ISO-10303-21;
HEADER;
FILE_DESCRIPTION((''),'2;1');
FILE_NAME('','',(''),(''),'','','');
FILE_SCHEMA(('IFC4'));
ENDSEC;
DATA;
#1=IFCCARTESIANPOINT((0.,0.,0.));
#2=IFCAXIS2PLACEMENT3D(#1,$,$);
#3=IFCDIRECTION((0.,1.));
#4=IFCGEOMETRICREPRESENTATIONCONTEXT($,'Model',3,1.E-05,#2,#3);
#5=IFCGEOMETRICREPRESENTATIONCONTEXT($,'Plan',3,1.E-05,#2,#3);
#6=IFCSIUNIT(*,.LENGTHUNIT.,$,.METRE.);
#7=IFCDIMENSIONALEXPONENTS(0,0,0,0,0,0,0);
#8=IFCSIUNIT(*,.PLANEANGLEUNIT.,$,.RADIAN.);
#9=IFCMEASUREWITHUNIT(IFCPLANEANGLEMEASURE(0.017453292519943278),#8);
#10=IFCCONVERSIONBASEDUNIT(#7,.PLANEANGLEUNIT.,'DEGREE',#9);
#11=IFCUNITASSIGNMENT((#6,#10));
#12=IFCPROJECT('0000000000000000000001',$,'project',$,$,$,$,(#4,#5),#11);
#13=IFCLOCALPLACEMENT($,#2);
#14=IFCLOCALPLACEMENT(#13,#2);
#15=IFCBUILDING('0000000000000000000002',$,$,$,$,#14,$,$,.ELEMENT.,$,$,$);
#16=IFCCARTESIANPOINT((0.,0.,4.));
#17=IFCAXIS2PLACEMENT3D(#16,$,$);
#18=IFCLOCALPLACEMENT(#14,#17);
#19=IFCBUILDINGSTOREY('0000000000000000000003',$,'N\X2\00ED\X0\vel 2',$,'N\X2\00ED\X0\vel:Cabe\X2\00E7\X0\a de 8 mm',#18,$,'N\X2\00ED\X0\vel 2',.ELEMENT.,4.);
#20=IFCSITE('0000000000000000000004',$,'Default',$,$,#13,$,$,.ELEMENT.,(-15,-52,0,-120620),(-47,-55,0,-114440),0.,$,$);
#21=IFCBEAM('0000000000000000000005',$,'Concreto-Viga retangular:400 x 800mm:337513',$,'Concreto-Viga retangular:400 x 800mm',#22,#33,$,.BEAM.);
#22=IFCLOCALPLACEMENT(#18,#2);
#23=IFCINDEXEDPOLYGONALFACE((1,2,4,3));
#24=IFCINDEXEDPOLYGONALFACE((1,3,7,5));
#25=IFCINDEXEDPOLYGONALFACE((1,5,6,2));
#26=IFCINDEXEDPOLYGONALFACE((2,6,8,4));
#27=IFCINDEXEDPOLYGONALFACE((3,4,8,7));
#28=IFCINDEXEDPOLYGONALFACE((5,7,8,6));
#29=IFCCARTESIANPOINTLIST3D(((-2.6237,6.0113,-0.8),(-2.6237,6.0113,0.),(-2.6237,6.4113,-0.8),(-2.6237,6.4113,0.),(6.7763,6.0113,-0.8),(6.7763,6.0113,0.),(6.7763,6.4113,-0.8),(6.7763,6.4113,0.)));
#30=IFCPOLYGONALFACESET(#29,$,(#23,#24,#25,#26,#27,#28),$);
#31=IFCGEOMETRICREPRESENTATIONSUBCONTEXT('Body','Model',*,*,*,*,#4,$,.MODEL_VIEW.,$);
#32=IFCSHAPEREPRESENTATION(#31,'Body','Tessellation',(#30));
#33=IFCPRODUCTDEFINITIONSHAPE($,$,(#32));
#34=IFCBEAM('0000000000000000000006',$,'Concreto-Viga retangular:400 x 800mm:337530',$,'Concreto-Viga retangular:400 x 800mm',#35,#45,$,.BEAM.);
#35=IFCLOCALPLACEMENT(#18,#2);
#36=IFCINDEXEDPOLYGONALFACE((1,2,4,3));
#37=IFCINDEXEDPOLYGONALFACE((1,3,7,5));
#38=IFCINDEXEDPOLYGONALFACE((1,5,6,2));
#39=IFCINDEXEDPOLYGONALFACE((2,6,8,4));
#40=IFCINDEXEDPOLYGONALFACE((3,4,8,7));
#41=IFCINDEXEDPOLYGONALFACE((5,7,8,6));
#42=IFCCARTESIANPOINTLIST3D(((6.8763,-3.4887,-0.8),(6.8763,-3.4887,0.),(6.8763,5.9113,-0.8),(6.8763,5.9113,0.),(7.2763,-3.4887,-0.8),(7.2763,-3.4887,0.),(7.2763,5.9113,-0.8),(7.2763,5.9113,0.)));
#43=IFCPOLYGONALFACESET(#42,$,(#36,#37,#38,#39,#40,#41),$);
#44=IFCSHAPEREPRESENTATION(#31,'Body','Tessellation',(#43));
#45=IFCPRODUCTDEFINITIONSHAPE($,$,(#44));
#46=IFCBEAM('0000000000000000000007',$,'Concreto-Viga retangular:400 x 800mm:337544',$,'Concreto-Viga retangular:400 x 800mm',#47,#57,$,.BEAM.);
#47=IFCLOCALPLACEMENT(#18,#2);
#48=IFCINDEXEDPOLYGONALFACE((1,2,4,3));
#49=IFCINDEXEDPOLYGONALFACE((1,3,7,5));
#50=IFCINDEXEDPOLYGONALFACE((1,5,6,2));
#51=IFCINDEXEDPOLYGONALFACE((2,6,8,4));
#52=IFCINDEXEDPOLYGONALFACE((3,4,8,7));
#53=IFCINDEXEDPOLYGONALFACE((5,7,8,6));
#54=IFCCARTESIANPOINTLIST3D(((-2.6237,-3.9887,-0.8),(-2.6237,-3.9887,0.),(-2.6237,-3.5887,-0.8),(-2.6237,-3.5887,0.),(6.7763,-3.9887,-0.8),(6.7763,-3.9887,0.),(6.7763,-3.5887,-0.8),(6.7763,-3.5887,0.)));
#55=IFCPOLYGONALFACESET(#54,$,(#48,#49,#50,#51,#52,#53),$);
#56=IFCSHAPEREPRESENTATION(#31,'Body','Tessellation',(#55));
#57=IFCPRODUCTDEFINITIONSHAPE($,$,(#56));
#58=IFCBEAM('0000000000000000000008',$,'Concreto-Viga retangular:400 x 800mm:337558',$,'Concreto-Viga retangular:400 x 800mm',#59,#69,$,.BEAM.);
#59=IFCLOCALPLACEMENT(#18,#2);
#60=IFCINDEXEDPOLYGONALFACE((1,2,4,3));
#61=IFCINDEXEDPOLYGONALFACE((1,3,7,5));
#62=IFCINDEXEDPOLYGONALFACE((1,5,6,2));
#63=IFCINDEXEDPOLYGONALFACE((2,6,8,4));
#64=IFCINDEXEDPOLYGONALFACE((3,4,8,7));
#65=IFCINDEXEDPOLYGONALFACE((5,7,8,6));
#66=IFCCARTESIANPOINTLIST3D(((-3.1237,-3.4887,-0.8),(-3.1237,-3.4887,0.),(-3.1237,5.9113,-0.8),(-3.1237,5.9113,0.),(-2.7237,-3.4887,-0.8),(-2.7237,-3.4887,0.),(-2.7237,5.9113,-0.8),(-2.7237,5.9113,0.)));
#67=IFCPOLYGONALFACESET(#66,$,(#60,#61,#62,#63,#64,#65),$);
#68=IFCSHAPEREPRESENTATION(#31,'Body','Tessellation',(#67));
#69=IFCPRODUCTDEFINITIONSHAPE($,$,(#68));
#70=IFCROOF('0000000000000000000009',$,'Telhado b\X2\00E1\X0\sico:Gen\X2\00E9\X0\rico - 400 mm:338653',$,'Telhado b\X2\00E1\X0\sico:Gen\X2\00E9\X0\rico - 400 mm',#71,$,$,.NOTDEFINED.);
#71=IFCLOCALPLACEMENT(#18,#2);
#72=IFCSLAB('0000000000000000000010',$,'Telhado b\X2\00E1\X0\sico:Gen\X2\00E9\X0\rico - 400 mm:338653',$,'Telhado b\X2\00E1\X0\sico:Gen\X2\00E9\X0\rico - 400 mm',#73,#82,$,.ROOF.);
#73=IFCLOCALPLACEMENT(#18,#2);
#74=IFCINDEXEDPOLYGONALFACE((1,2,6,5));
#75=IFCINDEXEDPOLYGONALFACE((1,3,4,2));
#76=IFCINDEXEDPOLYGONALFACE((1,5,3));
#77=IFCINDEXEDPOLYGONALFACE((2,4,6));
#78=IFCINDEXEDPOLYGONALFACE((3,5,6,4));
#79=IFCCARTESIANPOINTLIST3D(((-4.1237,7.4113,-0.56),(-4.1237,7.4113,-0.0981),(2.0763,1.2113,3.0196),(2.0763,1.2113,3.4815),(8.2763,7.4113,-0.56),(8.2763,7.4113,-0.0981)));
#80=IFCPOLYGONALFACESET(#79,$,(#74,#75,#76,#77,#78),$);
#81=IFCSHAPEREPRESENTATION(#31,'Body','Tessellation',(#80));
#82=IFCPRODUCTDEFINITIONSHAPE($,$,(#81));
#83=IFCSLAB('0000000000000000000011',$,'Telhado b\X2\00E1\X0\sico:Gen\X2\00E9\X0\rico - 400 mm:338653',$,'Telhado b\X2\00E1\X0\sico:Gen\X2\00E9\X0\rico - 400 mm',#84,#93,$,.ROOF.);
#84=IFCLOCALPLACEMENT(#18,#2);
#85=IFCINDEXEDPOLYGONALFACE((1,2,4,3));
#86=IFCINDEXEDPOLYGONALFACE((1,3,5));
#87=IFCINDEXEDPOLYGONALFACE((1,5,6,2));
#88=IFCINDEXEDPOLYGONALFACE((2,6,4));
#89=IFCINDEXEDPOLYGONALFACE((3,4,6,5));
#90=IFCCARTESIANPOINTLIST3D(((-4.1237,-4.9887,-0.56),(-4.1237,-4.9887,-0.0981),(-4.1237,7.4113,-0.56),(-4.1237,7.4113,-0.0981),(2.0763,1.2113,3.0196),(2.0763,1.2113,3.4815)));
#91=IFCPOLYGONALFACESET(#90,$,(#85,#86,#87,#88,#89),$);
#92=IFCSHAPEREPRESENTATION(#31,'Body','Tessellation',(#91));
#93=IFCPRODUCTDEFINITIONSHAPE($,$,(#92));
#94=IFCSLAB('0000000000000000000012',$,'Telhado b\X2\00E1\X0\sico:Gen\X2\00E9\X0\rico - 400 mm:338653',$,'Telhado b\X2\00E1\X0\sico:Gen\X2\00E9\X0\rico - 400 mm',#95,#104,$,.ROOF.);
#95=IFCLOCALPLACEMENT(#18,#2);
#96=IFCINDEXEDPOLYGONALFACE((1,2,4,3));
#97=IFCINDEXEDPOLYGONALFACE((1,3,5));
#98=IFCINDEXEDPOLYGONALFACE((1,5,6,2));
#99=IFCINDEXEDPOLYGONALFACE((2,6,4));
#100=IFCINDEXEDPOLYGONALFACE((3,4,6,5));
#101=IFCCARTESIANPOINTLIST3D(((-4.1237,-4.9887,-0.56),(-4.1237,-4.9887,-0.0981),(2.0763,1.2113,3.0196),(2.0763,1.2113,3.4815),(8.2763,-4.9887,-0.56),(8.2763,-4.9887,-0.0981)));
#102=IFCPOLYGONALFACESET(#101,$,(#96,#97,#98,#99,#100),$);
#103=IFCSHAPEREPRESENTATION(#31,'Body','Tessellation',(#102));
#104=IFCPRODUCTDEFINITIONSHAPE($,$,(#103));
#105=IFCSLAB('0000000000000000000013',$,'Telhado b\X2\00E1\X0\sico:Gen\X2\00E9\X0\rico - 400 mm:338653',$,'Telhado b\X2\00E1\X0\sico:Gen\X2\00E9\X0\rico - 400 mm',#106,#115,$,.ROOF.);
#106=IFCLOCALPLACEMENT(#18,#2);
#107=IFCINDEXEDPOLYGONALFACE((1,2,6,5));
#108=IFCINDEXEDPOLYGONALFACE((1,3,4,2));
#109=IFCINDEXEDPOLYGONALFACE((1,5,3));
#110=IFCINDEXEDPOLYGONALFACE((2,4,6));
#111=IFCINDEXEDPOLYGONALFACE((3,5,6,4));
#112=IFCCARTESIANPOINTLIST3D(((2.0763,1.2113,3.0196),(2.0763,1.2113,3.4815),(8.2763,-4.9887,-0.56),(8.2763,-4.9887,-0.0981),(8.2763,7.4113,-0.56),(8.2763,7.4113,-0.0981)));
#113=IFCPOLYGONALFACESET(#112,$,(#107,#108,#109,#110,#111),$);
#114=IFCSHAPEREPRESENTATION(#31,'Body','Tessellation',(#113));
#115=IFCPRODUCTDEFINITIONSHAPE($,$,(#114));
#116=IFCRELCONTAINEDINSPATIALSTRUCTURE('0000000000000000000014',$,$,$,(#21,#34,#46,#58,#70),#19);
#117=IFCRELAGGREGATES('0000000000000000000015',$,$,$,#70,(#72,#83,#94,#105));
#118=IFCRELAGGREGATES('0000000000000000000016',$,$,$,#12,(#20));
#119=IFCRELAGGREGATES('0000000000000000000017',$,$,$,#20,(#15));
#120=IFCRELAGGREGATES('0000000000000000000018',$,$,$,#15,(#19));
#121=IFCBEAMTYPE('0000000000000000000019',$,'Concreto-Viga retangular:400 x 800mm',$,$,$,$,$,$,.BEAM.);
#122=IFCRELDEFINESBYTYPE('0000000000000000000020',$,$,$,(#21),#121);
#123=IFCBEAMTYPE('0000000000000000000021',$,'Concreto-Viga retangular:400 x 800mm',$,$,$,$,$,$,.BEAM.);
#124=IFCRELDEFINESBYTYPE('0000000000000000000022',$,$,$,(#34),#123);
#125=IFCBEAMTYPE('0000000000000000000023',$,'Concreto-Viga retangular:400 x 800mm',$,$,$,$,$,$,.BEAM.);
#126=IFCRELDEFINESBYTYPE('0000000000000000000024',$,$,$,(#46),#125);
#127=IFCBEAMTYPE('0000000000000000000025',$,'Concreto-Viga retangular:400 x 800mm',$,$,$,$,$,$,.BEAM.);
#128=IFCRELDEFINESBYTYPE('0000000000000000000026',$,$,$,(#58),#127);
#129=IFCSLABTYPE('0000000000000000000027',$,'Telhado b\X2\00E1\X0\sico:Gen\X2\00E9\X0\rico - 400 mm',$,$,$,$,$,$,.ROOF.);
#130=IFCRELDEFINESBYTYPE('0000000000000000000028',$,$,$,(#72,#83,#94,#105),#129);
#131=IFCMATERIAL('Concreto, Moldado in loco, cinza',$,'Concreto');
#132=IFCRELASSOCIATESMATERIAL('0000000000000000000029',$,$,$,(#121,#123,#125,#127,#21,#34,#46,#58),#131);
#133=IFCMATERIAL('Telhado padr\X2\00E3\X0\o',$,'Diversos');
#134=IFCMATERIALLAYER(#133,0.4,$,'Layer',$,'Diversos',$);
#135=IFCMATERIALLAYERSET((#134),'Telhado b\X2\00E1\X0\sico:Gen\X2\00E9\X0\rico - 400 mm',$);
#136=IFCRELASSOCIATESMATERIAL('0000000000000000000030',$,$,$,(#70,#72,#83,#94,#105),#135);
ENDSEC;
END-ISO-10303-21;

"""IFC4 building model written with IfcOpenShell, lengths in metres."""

from ifc_helpers import new_model, entity, si_unit, converted_unit, direction, frame, frame_2d, origin, origin_2d_with_axis, place, context, subcontext, project, spatial, polyline, rectangle, outline, extrude, source, transform, mapped, material, layer, layer_set, material_profile, profile_set, profile_usage, type_object, type_shapes, element, aggregate, save


model = new_model("IFC4")

# Units and contexts
model_context = context("Model", 3, precision=1e-05, world=origin(), true_north=direction((0.0, 1.0)))
plan_context = context("Plan", 3, precision=1e-05, world=origin(), true_north=direction((0.0, 1.0)))
body_context = subcontext(model_context, "Body", "Model", "MODEL_VIEW")
ifc_project = project(units=[si_unit("LENGTHUNIT", "METRE"), converted_unit("PLANEANGLEUNIT", "DEGREE", entity("IfcPlaneAngleMeasure", 0.017453292519943278), si_unit("PLANEANGLEUNIT", "RADIAN"), dimensions=[0, 0, 0, 0, 0, 0, 0])], contexts=[model_context, plan_context])

# Site, building, storey
site_placement = place(None, origin())
site = spatial("IfcSite", under=ifc_project, at=site_placement, Name="Default", CompositionType="ELEMENT", RefLatitude=(-15, -52, 0, -120620), RefLongitude=(-47, -55, 0, -114440), RefElevation=0.0)
building_placement = place(site_placement, origin())
building = spatial("IfcBuilding", under=site, at=building_placement, CompositionType="ELEMENT")
storey_placement = place(building_placement, frame((0.0, 0.0, 4.0)))
storey = spatial("IfcBuildingStorey", under=building, at=storey_placement, Name="Nível 2", ObjectType="Nível:Cabeça de 8 mm", LongName="Nível 2", CompositionType="ELEMENT", Elevation=4.0)

# Beams
ifc_material_1 = material(Name="Concreto, Moldado in loco, cinza", Category="Concreto")
ifc_material_profile = material_profile(ifc_material_1, rectangle(XDim=0.8, YDim=0.4, at=frame_2d((0.0, 0.0), x_axis=(1.0, 0.0))), Name="400 x 800mm")
ifc_profile_set = profile_set([ifc_material_profile], Name="400 x 800mm")
ifc_profile_usage = profile_usage(ifc_profile_set, cardinal=8)
beam_type_1 = type_object("IfcBeamType", Name="Concreto-Viga retangular:400 x 800mm", PredefinedType="BEAM", material=ifc_profile_set)
shared_shape_1 = source(origin(), body_context, "Body", "SweptSolid", [
    extrude(rectangle(XDim=0.8, YDim=0.4, at=frame_2d((0.0, 0.0), x_axis=(1.0, 0.0))), frame((-2.6237, 6.2113, 3.6), z_axis=(1.0, 0.0, 0.0), x_axis=(0.0, 0.0, -1.0)), (0.0, 0.0, 1.0), 9.4),
])
type_shapes(beam_type_1, [shared_shape_1])
beam_1_placement = place(storey_placement, frame((0.0, 0.0, -4.0)))
element("IfcBeam", 1, at=beam_1_placement, inside=storey, type_object=beam_type_1, material=ifc_profile_usage, Name="Concreto-Viga retangular:400 x 800mm:337513", ObjectType="Concreto-Viga retangular:400 x 800mm", PredefinedType="BEAM", context=body_context, shape_type="MappedRepresentation", body=[
    mapped(shared_shape_1, transform((0.0, 0.0, 0.0), scale=1.0)),
])
beam_type_2 = type_object("IfcBeamType", Name="Concreto-Viga retangular:400 x 800mm", PredefinedType="BEAM", material=ifc_profile_set)
shared_shape_2 = source(origin(), body_context, "Body", "SweptSolid", [
    extrude(rectangle(XDim=0.8, YDim=0.4, at=frame_2d((0.0, 0.0), x_axis=(0.0, 1.0))), frame((7.0763, 5.9113, 3.6), z_axis=(0.0, -1.0, 0.0), x_axis=(-1.0, 0.0, 0.0)), (0.0, 0.0, 1.0), 9.4),
])
type_shapes(beam_type_2, [shared_shape_2])
beam_2_placement = place(storey_placement, frame((0.0, 0.0, -4.0)))
element("IfcBeam", 2, at=beam_2_placement, inside=storey, type_object=beam_type_2, material=ifc_profile_usage, Name="Concreto-Viga retangular:400 x 800mm:337530", ObjectType="Concreto-Viga retangular:400 x 800mm", PredefinedType="BEAM", context=body_context, shape_type="MappedRepresentation", body=[
    mapped(shared_shape_2, transform((0.0, 0.0, 0.0), scale=1.0)),
])
beam_type_3 = type_object("IfcBeamType", Name="Concreto-Viga retangular:400 x 800mm", PredefinedType="BEAM", material=ifc_profile_set)
shared_shape_3 = source(origin(), body_context, "Body", "SweptSolid", [
    extrude(rectangle(XDim=0.8, YDim=0.4, at=origin_2d_with_axis()), frame((6.7763, -3.7887, 3.6), z_axis=(-1.0, 0.0, 0.0), x_axis=(0.0, 0.0, -1.0)), (0.0, 0.0, 1.0), 9.4),
])
type_shapes(beam_type_3, [shared_shape_3])
beam_3_placement = place(storey_placement, frame((0.0, 0.0, -4.0)))
element("IfcBeam", 3, at=beam_3_placement, inside=storey, type_object=beam_type_3, material=ifc_profile_usage, Name="Concreto-Viga retangular:400 x 800mm:337544", ObjectType="Concreto-Viga retangular:400 x 800mm", PredefinedType="BEAM", context=body_context, shape_type="MappedRepresentation", body=[
    mapped(shared_shape_3, transform((0.0, 0.0, 0.0), scale=1.0)),
])
beam_type_4 = type_object("IfcBeamType", Name="Concreto-Viga retangular:400 x 800mm", PredefinedType="BEAM", material=ifc_profile_set)
shared_shape_4 = source(origin(), body_context, "Body", "SweptSolid", [
    extrude(rectangle(XDim=0.8, YDim=0.4, at=frame_2d((0.0, 0.0), x_axis=(0.0, 1.0))), frame((-2.9237, -3.4887, 3.6), z_axis=(0.0, 1.0, 0.0), x_axis=(-1.0, 0.0, 0.0)), (0.0, 0.0, 1.0), 9.4),
])
type_shapes(beam_type_4, [shared_shape_4])
beam_4_placement = place(storey_placement, frame((0.0, 0.0, -4.0)))
element("IfcBeam", 4, at=beam_4_placement, inside=storey, type_object=beam_type_4, material=ifc_profile_usage, Name="Concreto-Viga retangular:400 x 800mm:337558", ObjectType="Concreto-Viga retangular:400 x 800mm", PredefinedType="BEAM", context=body_context, shape_type="MappedRepresentation", body=[
    mapped(shared_shape_4, transform((0.0, 0.0, 0.0), scale=1.0)),
])

# Roof, slabs
ifc_material_2 = material(Name="Telhado padrão", Category="Diversos")
ifc_layer = layer(ifc_material_2, 0.4, Name="Layer", Category="Diversos")
ifc_layer_set = layer_set([ifc_layer], Name="Telhado básico:Genérico - 400 mm")
roof_placement = place(storey_placement, frame((-4.1237, -4.9887, -0.56)))
roof = element("IfcRoof", 5, at=roof_placement, inside=storey, material=ifc_layer_set, Name="Telhado básico:Genérico - 400 mm:338653", ObjectType="Telhado básico:Genérico - 400 mm", PredefinedType="NOTDEFINED")
slab_type = type_object("IfcSlabType", Name="Telhado básico:Genérico - 400 mm", PredefinedType="ROOF")
slab_1_placement = place(roof_placement, origin())
slab_1 = element("IfcSlab", 6, at=slab_1_placement, type_object=slab_type, material=ifc_layer_set, Name="Telhado básico:Genérico - 400 mm:338653", ObjectType="Telhado básico:Genérico - 400 mm", PredefinedType="ROOF", context=body_context, shape_type="SweptSolid", body=[
    extrude(outline(polyline([(6.2, 3.5796), (-6.2, 3.5796), (0.0, -3.5796), (6.2, 3.5796)])), frame((6.2, 9.3, 1.7898), z_axis=(0.0, 0.5, 0.866025), x_axis=(1.0, 0.0, 0.0)), (0.0, -0.5, 0.866025), 0.4619),
])
slab_2_placement = place(roof_placement, origin())
slab_2 = element("IfcSlab", 7, at=slab_2_placement, type_object=slab_type, material=ifc_layer_set, Name="Telhado básico:Genérico - 400 mm:338653", ObjectType="Telhado básico:Genérico - 400 mm", PredefinedType="ROOF", context=body_context, shape_type="SweptSolid", body=[
    extrude(outline(polyline([(-3.5796, 6.2), (-3.5796, -6.2), (3.5796, 0.0), (-3.5796, 6.2)])), frame((3.1, 6.2, 1.7898), z_axis=(-0.5, 0.0, 0.866025), x_axis=(0.866025, 0.0, 0.5)), (0.5, 0.0, 0.866025), 0.4619),
])
slab_3_placement = place(roof_placement, origin())
slab_3 = element("IfcSlab", 8, at=slab_3_placement, type_object=slab_type, material=ifc_layer_set, Name="Telhado básico:Genérico - 400 mm:338653", ObjectType="Telhado básico:Genérico - 400 mm", PredefinedType="ROOF", context=body_context, shape_type="SweptSolid", body=[
    extrude(outline(polyline([(-6.2, -3.5796), (6.2, -3.5796), (0.0, 3.5796), (-6.2, -3.5796)])), frame((6.2, 3.1, 1.7898), z_axis=(0.0, -0.5, 0.866025), x_axis=(1.0, 0.0, 0.0)), (0.0, 0.5, 0.866025), 0.4619),
])
slab_4_placement = place(roof_placement, origin())
slab_4 = element("IfcSlab", 9, at=slab_4_placement, type_object=slab_type, material=ifc_layer_set, Name="Telhado básico:Genérico - 400 mm:338653", ObjectType="Telhado básico:Genérico - 400 mm", PredefinedType="ROOF", context=body_context, shape_type="SweptSolid", body=[
    extrude(outline(polyline([(-3.5796, 0.0), (3.5796, -6.2), (3.5796, 6.2), (-3.5796, 0.0)])), frame((9.3, 6.2, 1.7898), z_axis=(0.5, 0.0, 0.866025), x_axis=(0.866025, 0.0, -0.5)), (-0.5, 0.0, 0.866025), 0.4619),
])
aggregate(roof, [slab_1, slab_2, slab_3, slab_4])

save(model, "model.ifc")
